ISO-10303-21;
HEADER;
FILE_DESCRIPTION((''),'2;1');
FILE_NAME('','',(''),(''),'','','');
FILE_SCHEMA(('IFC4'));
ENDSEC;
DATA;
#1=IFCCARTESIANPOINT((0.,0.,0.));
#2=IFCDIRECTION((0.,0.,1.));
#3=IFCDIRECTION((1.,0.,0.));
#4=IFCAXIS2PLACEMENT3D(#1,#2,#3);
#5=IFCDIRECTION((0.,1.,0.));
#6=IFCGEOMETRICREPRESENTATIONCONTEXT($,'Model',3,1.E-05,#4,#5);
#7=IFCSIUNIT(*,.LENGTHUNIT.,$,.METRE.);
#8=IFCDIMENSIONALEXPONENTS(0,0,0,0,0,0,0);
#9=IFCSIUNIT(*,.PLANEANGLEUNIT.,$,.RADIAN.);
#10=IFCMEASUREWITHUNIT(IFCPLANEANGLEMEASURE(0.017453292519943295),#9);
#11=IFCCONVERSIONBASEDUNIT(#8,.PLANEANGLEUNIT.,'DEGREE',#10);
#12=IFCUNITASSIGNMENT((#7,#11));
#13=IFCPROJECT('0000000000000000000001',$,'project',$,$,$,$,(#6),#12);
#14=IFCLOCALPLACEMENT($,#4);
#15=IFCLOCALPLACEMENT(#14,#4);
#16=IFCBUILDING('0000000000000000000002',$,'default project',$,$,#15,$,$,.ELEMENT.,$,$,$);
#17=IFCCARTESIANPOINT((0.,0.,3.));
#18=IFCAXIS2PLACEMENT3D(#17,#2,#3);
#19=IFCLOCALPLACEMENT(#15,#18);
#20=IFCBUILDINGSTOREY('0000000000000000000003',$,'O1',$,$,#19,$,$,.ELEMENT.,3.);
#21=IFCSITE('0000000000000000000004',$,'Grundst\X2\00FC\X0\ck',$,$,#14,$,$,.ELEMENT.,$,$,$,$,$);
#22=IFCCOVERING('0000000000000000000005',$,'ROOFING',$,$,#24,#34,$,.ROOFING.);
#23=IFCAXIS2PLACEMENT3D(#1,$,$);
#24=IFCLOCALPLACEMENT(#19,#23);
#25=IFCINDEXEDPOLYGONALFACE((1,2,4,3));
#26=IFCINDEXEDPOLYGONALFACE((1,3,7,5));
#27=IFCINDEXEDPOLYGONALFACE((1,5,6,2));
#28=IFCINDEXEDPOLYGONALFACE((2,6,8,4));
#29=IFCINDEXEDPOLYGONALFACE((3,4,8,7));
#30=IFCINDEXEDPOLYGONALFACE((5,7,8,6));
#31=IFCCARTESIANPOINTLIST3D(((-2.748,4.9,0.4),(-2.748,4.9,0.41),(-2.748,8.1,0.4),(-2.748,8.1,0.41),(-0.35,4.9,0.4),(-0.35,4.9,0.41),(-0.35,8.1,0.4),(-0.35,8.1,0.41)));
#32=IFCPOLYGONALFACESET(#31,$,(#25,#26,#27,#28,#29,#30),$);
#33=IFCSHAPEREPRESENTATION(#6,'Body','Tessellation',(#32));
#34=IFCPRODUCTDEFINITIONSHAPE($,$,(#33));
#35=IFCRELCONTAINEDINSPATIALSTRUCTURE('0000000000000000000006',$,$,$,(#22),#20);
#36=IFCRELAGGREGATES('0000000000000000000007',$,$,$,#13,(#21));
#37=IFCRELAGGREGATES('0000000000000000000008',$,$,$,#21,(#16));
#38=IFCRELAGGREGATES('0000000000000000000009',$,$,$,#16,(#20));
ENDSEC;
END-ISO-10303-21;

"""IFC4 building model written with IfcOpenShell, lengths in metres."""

from ifc_helpers import new_model, entity, si_unit, converted_unit, direction, frame, origin_with_axes, place, context, project, spatial, polyline, outline, extrude, element, save


model = new_model("IFC4")

# Units and contexts
model_context = context("Model", 3, precision=1e-05, world=origin_with_axes(), true_north=direction((0.0, 1.0, 0.0)))
ifc_project = project(units=[si_unit("LENGTHUNIT", "METRE"), converted_unit("PLANEANGLEUNIT", "DEGREE", entity("IfcPlaneAngleMeasure", 0.017453292519943295), si_unit("PLANEANGLEUNIT", "RADIAN"), dimensions=[0, 0, 0, 0, 0, 0, 0])], contexts=[model_context])

# Site, building, storey
site_placement = place(None, origin_with_axes())
site = spatial("IfcSite", under=ifc_project, at=site_placement, Name="Grundstück", CompositionType="ELEMENT")
building_placement = place(site_placement, origin_with_axes())
building = spatial("IfcBuilding", under=site, at=building_placement, Name="default project", CompositionType="ELEMENT")
placement_1 = place(building_placement, frame((0.0, 0.0, 3.0), z_axis=(0.0, 0.0, 1.0), x_axis=(1.0, 0.0, 0.0)))
storey = spatial("IfcBuildingStorey", under=building, at=placement_1, Name="O1", CompositionType="ELEMENT", Elevation=3.0)

# Shared definitions
slab_1_placement = place(placement_1, origin_with_axes())

# Covering
covering_1_placement = place(slab_1_placement, frame((0.0, 0.0, 0.2), z_axis=(0.0, 0.0, 1.0), x_axis=(1.0, 0.0, 0.0)))
element("IfcCovering", 1, at=covering_1_placement, inside=storey, Name="ROOFING", PredefinedType="ROOFING", context=model_context, shape_type="SweptSolid", body=[
    extrude(outline(polyline([(-0.35, 8.1), (-2.748, 8.1), (-2.748, 4.9), (-0.35, 4.9), (-0.35, 8.1)])), frame((0.0, 0.0, 0.2), z_axis=(0.0, 0.0, 1.0), x_axis=(1.0, 0.0, 0.0)), (0.0, 0.0, 1.0), 0.01),
])

save(model, "model.ifc")
